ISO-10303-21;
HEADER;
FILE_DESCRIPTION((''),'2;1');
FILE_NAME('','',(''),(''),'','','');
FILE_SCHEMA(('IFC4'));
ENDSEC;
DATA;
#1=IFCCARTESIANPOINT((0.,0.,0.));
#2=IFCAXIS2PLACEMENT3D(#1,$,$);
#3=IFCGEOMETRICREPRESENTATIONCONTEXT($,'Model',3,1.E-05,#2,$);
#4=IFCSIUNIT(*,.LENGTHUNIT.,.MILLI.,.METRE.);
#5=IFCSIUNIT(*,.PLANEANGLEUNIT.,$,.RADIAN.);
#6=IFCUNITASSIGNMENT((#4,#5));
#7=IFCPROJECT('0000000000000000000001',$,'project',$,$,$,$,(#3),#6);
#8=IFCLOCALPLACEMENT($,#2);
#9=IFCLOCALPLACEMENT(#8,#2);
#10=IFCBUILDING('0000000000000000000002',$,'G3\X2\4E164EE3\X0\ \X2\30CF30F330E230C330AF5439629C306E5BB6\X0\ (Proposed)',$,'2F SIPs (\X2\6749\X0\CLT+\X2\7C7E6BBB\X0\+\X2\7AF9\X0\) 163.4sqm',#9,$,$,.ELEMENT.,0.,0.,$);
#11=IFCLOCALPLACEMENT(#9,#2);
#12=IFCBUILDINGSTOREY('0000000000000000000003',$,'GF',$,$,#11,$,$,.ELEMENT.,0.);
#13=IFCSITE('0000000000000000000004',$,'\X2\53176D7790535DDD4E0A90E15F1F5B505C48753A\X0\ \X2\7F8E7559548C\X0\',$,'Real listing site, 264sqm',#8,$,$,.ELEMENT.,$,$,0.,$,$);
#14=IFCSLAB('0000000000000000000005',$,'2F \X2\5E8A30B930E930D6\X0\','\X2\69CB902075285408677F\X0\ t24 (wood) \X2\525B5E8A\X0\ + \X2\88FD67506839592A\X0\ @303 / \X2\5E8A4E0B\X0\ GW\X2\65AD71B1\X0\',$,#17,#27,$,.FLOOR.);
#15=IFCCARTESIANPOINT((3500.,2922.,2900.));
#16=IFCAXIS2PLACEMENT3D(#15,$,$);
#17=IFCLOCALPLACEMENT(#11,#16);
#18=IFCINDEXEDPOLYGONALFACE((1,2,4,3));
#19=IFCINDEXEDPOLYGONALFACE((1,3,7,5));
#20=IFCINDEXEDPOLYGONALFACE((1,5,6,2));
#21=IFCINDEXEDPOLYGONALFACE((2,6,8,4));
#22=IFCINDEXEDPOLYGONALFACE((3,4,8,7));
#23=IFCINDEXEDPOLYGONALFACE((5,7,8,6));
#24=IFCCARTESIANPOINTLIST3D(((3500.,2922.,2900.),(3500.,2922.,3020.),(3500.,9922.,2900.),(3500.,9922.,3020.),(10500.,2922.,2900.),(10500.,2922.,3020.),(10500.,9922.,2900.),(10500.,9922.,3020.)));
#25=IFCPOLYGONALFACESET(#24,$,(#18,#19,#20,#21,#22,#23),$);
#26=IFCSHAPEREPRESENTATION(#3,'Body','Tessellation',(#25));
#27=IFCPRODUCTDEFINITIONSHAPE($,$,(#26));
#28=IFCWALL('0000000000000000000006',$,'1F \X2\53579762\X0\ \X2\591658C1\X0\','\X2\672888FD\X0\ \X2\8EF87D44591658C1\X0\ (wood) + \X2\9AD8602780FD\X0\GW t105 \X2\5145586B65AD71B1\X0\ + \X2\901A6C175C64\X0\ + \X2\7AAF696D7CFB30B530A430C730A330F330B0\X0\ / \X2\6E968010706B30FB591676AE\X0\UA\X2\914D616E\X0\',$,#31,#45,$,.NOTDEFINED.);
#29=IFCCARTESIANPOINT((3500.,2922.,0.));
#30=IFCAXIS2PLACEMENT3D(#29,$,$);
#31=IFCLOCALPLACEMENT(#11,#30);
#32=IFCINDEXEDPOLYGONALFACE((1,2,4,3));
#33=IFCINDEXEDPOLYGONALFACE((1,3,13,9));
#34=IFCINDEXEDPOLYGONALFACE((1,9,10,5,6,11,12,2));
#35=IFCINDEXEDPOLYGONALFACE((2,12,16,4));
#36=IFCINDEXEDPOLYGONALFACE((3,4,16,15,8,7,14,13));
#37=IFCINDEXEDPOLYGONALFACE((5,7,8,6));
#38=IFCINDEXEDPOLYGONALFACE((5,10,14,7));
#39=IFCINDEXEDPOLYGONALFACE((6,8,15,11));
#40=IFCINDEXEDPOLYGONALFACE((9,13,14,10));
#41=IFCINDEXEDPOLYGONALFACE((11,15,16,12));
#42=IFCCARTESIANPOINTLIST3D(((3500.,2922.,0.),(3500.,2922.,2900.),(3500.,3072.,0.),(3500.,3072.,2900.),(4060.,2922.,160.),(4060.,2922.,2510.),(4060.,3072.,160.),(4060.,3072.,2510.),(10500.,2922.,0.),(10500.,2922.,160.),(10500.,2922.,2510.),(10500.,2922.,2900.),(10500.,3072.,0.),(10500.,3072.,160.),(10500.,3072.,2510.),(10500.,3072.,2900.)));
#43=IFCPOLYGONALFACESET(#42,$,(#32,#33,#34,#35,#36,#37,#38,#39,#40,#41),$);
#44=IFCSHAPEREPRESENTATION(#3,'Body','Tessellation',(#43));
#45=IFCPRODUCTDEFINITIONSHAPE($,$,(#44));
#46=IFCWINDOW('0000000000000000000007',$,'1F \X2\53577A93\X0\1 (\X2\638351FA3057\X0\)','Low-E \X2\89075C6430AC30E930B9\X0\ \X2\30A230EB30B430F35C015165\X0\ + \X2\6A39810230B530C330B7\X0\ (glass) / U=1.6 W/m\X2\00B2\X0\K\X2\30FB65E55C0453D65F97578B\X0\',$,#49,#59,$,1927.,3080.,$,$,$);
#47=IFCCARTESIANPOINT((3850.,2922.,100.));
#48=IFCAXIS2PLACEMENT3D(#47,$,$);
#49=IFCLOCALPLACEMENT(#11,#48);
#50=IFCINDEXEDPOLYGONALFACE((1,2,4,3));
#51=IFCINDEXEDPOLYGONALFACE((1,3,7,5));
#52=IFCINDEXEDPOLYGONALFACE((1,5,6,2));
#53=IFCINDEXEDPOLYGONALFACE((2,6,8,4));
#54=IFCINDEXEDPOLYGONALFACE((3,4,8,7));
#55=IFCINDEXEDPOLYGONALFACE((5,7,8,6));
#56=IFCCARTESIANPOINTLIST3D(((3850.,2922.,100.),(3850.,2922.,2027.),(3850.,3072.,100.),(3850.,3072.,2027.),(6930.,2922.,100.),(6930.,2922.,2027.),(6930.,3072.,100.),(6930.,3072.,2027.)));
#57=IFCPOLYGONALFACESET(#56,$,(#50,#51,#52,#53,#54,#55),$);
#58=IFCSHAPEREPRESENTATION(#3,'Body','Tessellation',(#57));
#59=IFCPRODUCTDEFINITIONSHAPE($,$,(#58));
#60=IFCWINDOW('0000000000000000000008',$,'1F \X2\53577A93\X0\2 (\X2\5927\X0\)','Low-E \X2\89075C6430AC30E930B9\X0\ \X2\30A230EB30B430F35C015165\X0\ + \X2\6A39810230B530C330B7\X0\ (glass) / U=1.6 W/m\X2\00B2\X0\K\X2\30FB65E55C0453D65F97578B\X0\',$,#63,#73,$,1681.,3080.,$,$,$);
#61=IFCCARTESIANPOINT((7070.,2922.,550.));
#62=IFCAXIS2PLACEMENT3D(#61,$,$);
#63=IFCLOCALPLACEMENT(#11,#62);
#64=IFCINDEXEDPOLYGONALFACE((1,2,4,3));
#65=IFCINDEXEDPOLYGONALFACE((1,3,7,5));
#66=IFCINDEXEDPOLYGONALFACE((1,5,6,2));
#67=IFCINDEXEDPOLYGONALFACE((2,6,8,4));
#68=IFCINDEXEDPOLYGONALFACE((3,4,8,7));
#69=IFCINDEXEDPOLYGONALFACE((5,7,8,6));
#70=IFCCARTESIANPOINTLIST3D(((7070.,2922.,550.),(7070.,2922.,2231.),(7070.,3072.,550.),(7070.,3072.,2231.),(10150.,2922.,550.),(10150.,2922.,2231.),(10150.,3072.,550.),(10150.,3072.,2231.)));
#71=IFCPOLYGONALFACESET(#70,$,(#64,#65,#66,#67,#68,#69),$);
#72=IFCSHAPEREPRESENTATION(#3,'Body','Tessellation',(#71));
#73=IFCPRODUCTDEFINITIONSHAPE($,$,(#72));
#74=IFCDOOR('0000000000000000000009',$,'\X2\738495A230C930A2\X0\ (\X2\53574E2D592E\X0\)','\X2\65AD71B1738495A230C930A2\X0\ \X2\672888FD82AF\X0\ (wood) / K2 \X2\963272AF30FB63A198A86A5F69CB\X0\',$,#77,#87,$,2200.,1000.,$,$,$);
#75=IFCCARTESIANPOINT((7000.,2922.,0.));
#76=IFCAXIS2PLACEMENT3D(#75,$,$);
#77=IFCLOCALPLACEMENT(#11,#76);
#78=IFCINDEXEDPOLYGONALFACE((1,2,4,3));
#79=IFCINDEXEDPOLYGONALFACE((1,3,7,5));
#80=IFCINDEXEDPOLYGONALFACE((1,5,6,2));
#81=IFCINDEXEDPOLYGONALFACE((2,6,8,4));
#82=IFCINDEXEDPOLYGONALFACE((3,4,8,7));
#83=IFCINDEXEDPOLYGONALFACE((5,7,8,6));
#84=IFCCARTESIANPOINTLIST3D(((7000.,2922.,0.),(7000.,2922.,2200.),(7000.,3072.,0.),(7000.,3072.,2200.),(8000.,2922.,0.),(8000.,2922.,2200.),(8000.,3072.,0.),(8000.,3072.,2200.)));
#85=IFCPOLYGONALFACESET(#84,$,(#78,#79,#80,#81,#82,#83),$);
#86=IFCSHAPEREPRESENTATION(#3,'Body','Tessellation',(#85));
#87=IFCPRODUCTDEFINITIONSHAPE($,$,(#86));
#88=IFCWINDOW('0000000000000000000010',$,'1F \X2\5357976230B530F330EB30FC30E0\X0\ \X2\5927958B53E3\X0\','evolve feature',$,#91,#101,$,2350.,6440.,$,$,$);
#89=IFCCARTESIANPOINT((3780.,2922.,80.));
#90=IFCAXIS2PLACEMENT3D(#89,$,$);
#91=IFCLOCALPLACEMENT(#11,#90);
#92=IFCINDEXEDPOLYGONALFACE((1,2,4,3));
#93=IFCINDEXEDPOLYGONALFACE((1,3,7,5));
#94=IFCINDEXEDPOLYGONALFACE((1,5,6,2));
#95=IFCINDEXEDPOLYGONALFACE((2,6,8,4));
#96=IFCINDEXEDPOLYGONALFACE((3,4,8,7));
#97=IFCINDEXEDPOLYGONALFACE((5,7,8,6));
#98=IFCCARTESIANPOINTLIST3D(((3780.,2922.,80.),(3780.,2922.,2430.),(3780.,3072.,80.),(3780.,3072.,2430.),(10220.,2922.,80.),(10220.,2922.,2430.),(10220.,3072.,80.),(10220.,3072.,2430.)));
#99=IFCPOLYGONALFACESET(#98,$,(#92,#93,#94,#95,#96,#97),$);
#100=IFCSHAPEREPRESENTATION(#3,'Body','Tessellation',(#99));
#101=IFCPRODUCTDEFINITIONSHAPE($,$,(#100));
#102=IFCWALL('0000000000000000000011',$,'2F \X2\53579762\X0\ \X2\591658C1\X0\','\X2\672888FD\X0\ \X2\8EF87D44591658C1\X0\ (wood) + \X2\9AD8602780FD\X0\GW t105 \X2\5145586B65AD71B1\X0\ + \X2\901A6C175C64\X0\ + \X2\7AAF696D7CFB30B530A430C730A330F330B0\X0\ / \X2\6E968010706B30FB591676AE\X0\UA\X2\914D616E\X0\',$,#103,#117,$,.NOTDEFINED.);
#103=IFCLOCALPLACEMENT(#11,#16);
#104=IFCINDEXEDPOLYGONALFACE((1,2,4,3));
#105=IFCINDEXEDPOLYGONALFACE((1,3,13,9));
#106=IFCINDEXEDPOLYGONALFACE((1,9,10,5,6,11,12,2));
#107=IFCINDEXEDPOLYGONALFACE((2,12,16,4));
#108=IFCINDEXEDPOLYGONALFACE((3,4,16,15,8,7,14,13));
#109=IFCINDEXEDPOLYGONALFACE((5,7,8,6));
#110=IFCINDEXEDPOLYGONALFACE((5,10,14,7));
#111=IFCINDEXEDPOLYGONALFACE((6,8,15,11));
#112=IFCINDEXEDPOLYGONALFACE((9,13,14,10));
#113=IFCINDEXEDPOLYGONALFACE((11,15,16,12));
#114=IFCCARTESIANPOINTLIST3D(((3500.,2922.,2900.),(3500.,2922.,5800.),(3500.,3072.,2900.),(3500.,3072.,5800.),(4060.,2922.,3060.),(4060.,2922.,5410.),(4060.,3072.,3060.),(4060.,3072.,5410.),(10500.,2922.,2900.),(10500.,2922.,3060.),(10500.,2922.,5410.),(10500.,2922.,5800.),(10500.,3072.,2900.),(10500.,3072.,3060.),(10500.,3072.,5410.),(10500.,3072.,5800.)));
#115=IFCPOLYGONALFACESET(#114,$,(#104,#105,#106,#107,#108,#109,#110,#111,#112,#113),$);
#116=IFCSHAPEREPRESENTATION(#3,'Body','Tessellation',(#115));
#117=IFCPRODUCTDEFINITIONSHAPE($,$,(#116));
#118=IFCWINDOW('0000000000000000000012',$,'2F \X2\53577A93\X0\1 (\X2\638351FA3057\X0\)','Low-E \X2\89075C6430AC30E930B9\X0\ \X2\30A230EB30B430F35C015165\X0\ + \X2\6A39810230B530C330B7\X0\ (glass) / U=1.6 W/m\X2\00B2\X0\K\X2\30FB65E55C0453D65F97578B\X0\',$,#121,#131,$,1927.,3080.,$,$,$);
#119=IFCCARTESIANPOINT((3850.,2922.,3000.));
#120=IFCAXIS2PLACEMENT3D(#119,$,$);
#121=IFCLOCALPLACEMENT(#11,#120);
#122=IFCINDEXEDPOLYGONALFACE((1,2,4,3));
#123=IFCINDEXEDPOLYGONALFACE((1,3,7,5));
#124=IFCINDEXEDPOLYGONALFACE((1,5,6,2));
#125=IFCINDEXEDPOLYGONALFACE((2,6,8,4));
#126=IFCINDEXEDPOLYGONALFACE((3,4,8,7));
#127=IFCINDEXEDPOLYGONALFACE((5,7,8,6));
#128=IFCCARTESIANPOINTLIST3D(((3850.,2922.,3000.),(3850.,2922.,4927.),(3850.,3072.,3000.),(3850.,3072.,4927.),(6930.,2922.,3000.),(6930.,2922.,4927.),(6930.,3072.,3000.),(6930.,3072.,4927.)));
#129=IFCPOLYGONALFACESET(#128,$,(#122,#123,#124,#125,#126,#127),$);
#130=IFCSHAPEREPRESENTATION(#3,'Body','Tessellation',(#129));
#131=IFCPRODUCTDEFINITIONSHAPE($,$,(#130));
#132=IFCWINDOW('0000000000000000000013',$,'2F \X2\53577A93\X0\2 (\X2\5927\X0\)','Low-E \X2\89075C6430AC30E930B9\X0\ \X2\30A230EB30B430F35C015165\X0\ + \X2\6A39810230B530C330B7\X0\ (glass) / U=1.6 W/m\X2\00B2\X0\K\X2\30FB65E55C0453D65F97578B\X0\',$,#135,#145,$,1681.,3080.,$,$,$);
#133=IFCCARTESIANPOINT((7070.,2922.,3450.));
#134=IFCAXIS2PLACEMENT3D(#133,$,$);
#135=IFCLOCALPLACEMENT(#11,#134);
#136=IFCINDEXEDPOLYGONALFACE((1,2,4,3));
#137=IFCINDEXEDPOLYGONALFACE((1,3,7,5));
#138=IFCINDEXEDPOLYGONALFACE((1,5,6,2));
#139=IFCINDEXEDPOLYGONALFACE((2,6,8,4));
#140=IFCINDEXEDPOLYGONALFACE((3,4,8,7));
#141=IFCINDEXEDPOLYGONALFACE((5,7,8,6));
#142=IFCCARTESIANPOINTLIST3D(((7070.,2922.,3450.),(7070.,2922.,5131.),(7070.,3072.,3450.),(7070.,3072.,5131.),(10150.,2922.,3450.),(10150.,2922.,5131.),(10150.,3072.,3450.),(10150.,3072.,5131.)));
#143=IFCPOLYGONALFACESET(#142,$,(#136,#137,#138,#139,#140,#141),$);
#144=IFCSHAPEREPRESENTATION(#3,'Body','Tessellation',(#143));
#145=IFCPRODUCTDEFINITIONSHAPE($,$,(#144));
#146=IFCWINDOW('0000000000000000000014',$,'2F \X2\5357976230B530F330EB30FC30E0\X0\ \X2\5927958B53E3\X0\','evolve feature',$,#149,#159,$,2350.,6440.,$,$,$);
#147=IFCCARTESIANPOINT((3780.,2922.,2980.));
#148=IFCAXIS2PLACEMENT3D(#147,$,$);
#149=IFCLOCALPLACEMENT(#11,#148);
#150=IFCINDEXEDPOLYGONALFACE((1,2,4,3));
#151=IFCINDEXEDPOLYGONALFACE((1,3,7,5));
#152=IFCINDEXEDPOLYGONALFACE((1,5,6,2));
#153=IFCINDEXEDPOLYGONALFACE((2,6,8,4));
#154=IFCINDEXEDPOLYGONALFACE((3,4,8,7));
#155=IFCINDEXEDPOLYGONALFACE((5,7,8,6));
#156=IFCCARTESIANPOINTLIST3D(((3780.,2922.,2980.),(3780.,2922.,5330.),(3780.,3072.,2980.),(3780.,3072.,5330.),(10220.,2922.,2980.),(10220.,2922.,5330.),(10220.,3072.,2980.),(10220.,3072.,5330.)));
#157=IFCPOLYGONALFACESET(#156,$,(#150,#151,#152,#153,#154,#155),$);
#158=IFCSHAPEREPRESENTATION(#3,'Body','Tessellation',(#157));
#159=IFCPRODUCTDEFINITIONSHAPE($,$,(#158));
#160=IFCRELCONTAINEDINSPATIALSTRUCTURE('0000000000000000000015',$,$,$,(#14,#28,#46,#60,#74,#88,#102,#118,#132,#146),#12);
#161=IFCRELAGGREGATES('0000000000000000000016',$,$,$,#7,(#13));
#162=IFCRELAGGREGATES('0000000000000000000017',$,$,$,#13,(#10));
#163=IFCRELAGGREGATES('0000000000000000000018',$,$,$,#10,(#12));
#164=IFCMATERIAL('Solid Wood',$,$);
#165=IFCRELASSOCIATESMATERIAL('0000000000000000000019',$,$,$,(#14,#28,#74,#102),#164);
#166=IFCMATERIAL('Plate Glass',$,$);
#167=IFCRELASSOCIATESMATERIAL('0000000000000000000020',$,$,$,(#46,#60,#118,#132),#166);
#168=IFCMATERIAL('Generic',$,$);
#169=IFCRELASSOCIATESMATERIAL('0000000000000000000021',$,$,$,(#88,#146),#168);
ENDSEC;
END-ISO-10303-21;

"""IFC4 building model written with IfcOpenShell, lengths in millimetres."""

from ifc_helpers import new_model, si_unit, frame, frame_2d, origin, place, context, project, spatial, rectangle, extrude, material, element, fill, save


model = new_model("IFC4")

# Units and contexts
model_context = context("Model", 3, precision=1e-05, world=origin())
ifc_project = project(units=[si_unit("LENGTHUNIT", "METRE", prefix="MILLI"), si_unit("PLANEANGLEUNIT", "RADIAN")], contexts=[model_context])

# Site, building, storey
site_placement = place(None, origin())
site = spatial("IfcSite", under=ifc_project, at=site_placement, Name="北海道川上郡弟子屈町 美留和", ObjectType="Real listing site, 264sqm", CompositionType="ELEMENT", RefElevation=0.0)
building_placement = place(site_placement, origin())
building = spatial("IfcBuilding", under=site, at=building_placement, Name="G3世代 ハンモック吹抜の家 (Proposed)", ObjectType="2F SIPs (杉CLT+籾殻+竹) 163.4sqm", CompositionType="ELEMENT", ElevationOfRefHeight=0.0, ElevationOfTerrain=0.0)
storey_placement = place(building_placement, origin())
storey = spatial("IfcBuildingStorey", under=building, at=storey_placement, Name="GF", CompositionType="ELEMENT", Elevation=0.0)

# Slab
ifc_material_1 = material(Name="Solid Wood")
slab_1_placement = place(storey_placement, frame((3500.0, 2922.0, 2900.0)))
element("IfcSlab", 1, at=slab_1_placement, inside=storey, material=ifc_material_1, Name="2F 床スラブ", Description="構造用合板 t24 (wood) 剛床 + 製材根太 @303 / 床下 GW断熱", PredefinedType="FLOOR", context=model_context, shape_type="SweptSolid", body=[
    extrude(rectangle(XDim=7000.0, YDim=7000.0, at=frame_2d((3500.0, 3500.0))), frame((3500.0, 2922.0, 2900.0)), (0.0, 0.0, 1.0), 120.0),
])
ifc_material_2 = material(Name="Generic")

# Wall, openings, windows, door
wall_1_placement = place(storey_placement, frame((3500.0, 2922.0, 0.0)))
wall_1 = element("IfcWall", 2, at=wall_1_placement, inside=storey, material=ifc_material_1, Name="1F 南面 外壁", Description="木製 軸組外壁 (wood) + 高性能GW t105 充填断熱 + 通気層 + 窯業系サイディング / 準耐火・外皮UA配慮", PredefinedType="NOTDEFINED", context=model_context, shape_type="SweptSolid", body=[
    extrude(rectangle(XDim=7000.0, YDim=150.0, at=frame_2d((3500.0, 75.0))), frame((3500.0, 2922.0, 0.0)), (0.0, 0.0, 1.0), 2900.0),
])
opening_1_placement = place(storey_placement, frame((3850.0, 2922.0, 100.0)))
opening_1 = element("IfcOpeningElement", 3, at=opening_1_placement, cuts=wall_1, PredefinedType="NOTDEFINED", context=model_context, shape_type="SweptSolid", body=[
    extrude(rectangle(XDim=3080.0, YDim=150.0, at=frame_2d((1540.0, 75.0))), frame((3850.0, 2922.0, 100.0)), (0.0, 0.0, 1.0), 1927.0),
])
opening_2_placement = place(storey_placement, frame((7070.0, 2922.0, 550.0)))
opening_2 = element("IfcOpeningElement", 4, at=opening_2_placement, cuts=wall_1, PredefinedType="NOTDEFINED", context=model_context, shape_type="SweptSolid", body=[
    extrude(rectangle(XDim=3080.0, YDim=150.0, at=frame_2d((1540.0, 75.0))), frame((7070.0, 2922.0, 550.0)), (0.0, 0.0, 1.0), 1681.0),
])
opening_3_placement = place(storey_placement, frame((7000.0, 2922.0, 0.0)))
opening_3 = element("IfcOpeningElement", 5, at=opening_3_placement, cuts=wall_1, PredefinedType="NOTDEFINED", context=model_context, shape_type="SweptSolid", body=[
    extrude(rectangle(XDim=1000.0, YDim=150.0, at=frame_2d((500.0, 75.0))), frame((7000.0, 2922.0, 0.0)), (0.0, 0.0, 1.0), 2200.0),
])
opening_4_placement = place(storey_placement, frame((3780.0, 2922.0, 80.0)))
opening_4 = element("IfcOpeningElement", 6, at=opening_4_placement, cuts=wall_1, PredefinedType="NOTDEFINED", context=model_context, shape_type="SweptSolid", body=[
    extrude(rectangle(XDim=6440.0, YDim=150.0, at=frame_2d((3220.0, 75.0))), frame((3780.0, 2922.0, 80.0)), (0.0, 0.0, 1.0), 2350.0),
])
ifc_material_3 = material(Name="Plate Glass")
window_1_placement = place(storey_placement, frame((3850.0, 2922.0, 100.0)))
window_1 = element("IfcWindow", 7, at=window_1_placement, inside=storey, material=ifc_material_3, Name="1F 南窓1 (掃出し)", Description="Low-E 複層ガラス アルゴン封入 + 樹脂サッシ (glass) / U=1.6 W/m²K・日射取得型", OverallHeight=1927.0, OverallWidth=3080.0, context=model_context, shape_type="SweptSolid", body=[
    extrude(rectangle(XDim=3080.0, YDim=150.0, at=frame_2d((1540.0, 75.0))), frame((3850.0, 2922.0, 100.0)), (0.0, 0.0, 1.0), 1927.0),
])
fill(opening_1, window_1)
window_2_placement = place(storey_placement, frame((7070.0, 2922.0, 550.0)))
window_2 = element("IfcWindow", 8, at=window_2_placement, inside=storey, material=ifc_material_3, Name="1F 南窓2 (大)", Description="Low-E 複層ガラス アルゴン封入 + 樹脂サッシ (glass) / U=1.6 W/m²K・日射取得型", OverallHeight=1681.0, OverallWidth=3080.0, context=model_context, shape_type="SweptSolid", body=[
    extrude(rectangle(XDim=3080.0, YDim=150.0, at=frame_2d((1540.0, 75.0))), frame((7070.0, 2922.0, 550.0)), (0.0, 0.0, 1.0), 1681.0),
])
fill(opening_2, window_2)
door_placement = place(storey_placement, frame((7000.0, 2922.0, 0.0)))
door = element("IfcDoor", 9, at=door_placement, inside=storey, material=ifc_material_1, Name="玄関ドア (南中央)", Description="断熱玄関ドア 木製芯 (wood) / K2 防犯・採風機構", OverallHeight=2200.0, OverallWidth=1000.0, context=model_context, shape_type="SweptSolid", body=[
    extrude(rectangle(XDim=1000.0, YDim=150.0, at=frame_2d((500.0, 75.0))), frame((7000.0, 2922.0, 0.0)), (0.0, 0.0, 1.0), 2200.0),
])
fill(opening_3, door)
window_3_placement = place(storey_placement, frame((3780.0, 2922.0, 80.0)))
window_3 = element("IfcWindow", 10, at=window_3_placement, inside=storey, material=ifc_material_2, Name="1F 南面サンルーム 大開口", Description="evolve feature", OverallHeight=2350.0, OverallWidth=6440.0, context=model_context, shape_type="SweptSolid", body=[
    extrude(rectangle(XDim=6440.0, YDim=150.0, at=frame_2d((3220.0, 75.0))), frame((3780.0, 2922.0, 80.0)), (0.0, 0.0, 1.0), 2350.0),
])
fill(opening_4, window_3)

# Wall, openings, windows
wall_2_placement = place(storey_placement, frame((3500.0, 2922.0, 2900.0)))
wall_2 = element("IfcWall", 11, at=wall_2_placement, inside=storey, material=ifc_material_1, Name="2F 南面 外壁", Description="木製 軸組外壁 (wood) + 高性能GW t105 充填断熱 + 通気層 + 窯業系サイディング / 準耐火・外皮UA配慮", PredefinedType="NOTDEFINED", context=model_context, shape_type="SweptSolid", body=[
    extrude(rectangle(XDim=7000.0, YDim=150.0, at=frame_2d((3500.0, 75.0))), frame((3500.0, 2922.0, 2900.0)), (0.0, 0.0, 1.0), 2900.0),
])
opening_5_placement = place(storey_placement, frame((3850.0, 2922.0, 3000.0)))
opening_5 = element("IfcOpeningElement", 12, at=opening_5_placement, cuts=wall_2, PredefinedType="NOTDEFINED", context=model_context, shape_type="SweptSolid", body=[
    extrude(rectangle(XDim=3080.0, YDim=150.0, at=frame_2d((1540.0, 75.0))), frame((3850.0, 2922.0, 3000.0)), (0.0, 0.0, 1.0), 1927.0),
])
opening_6_placement = place(storey_placement, frame((7070.0, 2922.0, 3450.0)))
opening_6 = element("IfcOpeningElement", 13, at=opening_6_placement, cuts=wall_2, PredefinedType="NOTDEFINED", context=model_context, shape_type="SweptSolid", body=[
    extrude(rectangle(XDim=3080.0, YDim=150.0, at=frame_2d((1540.0, 75.0))), frame((7070.0, 2922.0, 3450.0)), (0.0, 0.0, 1.0), 1681.0),
])
opening_7_placement = place(storey_placement, frame((3780.0, 2922.0, 2980.0)))
opening_7 = element("IfcOpeningElement", 14, at=opening_7_placement, cuts=wall_2, PredefinedType="NOTDEFINED", context=model_context, shape_type="SweptSolid", body=[
    extrude(rectangle(XDim=6440.0, YDim=150.0, at=frame_2d((3220.0, 75.0))), frame((3780.0, 2922.0, 2980.0)), (0.0, 0.0, 1.0), 2350.0),
])
window_4_placement = place(storey_placement, frame((3850.0, 2922.0, 3000.0)))
window_4 = element("IfcWindow", 15, at=window_4_placement, inside=storey, material=ifc_material_3, Name="2F 南窓1 (掃出し)", Description="Low-E 複層ガラス アルゴン封入 + 樹脂サッシ (glass) / U=1.6 W/m²K・日射取得型", OverallHeight=1927.0, OverallWidth=3080.0, context=model_context, shape_type="SweptSolid", body=[
    extrude(rectangle(XDim=3080.0, YDim=150.0, at=frame_2d((1540.0, 75.0))), frame((3850.0, 2922.0, 3000.0)), (0.0, 0.0, 1.0), 1927.0),
])
fill(opening_5, window_4)
window_5_placement = place(storey_placement, frame((7070.0, 2922.0, 3450.0)))
window_5 = element("IfcWindow", 16, at=window_5_placement, inside=storey, material=ifc_material_3, Name="2F 南窓2 (大)", Description="Low-E 複層ガラス アルゴン封入 + 樹脂サッシ (glass) / U=1.6 W/m²K・日射取得型", OverallHeight=1681.0, OverallWidth=3080.0, context=model_context, shape_type="SweptSolid", body=[
    extrude(rectangle(XDim=3080.0, YDim=150.0, at=frame_2d((1540.0, 75.0))), frame((7070.0, 2922.0, 3450.0)), (0.0, 0.0, 1.0), 1681.0),
])
fill(opening_6, window_5)
window_6_placement = place(storey_placement, frame((3780.0, 2922.0, 2980.0)))
window_6 = element("IfcWindow", 17, at=window_6_placement, inside=storey, material=ifc_material_2, Name="2F 南面サンルーム 大開口", Description="evolve feature", OverallHeight=2350.0, OverallWidth=6440.0, context=model_context, shape_type="SweptSolid", body=[
    extrude(rectangle(XDim=6440.0, YDim=150.0, at=frame_2d((3220.0, 75.0))), frame((3780.0, 2922.0, 2980.0)), (0.0, 0.0, 1.0), 2350.0),
])
fill(opening_7, window_6)

save(model, "model.ifc")
